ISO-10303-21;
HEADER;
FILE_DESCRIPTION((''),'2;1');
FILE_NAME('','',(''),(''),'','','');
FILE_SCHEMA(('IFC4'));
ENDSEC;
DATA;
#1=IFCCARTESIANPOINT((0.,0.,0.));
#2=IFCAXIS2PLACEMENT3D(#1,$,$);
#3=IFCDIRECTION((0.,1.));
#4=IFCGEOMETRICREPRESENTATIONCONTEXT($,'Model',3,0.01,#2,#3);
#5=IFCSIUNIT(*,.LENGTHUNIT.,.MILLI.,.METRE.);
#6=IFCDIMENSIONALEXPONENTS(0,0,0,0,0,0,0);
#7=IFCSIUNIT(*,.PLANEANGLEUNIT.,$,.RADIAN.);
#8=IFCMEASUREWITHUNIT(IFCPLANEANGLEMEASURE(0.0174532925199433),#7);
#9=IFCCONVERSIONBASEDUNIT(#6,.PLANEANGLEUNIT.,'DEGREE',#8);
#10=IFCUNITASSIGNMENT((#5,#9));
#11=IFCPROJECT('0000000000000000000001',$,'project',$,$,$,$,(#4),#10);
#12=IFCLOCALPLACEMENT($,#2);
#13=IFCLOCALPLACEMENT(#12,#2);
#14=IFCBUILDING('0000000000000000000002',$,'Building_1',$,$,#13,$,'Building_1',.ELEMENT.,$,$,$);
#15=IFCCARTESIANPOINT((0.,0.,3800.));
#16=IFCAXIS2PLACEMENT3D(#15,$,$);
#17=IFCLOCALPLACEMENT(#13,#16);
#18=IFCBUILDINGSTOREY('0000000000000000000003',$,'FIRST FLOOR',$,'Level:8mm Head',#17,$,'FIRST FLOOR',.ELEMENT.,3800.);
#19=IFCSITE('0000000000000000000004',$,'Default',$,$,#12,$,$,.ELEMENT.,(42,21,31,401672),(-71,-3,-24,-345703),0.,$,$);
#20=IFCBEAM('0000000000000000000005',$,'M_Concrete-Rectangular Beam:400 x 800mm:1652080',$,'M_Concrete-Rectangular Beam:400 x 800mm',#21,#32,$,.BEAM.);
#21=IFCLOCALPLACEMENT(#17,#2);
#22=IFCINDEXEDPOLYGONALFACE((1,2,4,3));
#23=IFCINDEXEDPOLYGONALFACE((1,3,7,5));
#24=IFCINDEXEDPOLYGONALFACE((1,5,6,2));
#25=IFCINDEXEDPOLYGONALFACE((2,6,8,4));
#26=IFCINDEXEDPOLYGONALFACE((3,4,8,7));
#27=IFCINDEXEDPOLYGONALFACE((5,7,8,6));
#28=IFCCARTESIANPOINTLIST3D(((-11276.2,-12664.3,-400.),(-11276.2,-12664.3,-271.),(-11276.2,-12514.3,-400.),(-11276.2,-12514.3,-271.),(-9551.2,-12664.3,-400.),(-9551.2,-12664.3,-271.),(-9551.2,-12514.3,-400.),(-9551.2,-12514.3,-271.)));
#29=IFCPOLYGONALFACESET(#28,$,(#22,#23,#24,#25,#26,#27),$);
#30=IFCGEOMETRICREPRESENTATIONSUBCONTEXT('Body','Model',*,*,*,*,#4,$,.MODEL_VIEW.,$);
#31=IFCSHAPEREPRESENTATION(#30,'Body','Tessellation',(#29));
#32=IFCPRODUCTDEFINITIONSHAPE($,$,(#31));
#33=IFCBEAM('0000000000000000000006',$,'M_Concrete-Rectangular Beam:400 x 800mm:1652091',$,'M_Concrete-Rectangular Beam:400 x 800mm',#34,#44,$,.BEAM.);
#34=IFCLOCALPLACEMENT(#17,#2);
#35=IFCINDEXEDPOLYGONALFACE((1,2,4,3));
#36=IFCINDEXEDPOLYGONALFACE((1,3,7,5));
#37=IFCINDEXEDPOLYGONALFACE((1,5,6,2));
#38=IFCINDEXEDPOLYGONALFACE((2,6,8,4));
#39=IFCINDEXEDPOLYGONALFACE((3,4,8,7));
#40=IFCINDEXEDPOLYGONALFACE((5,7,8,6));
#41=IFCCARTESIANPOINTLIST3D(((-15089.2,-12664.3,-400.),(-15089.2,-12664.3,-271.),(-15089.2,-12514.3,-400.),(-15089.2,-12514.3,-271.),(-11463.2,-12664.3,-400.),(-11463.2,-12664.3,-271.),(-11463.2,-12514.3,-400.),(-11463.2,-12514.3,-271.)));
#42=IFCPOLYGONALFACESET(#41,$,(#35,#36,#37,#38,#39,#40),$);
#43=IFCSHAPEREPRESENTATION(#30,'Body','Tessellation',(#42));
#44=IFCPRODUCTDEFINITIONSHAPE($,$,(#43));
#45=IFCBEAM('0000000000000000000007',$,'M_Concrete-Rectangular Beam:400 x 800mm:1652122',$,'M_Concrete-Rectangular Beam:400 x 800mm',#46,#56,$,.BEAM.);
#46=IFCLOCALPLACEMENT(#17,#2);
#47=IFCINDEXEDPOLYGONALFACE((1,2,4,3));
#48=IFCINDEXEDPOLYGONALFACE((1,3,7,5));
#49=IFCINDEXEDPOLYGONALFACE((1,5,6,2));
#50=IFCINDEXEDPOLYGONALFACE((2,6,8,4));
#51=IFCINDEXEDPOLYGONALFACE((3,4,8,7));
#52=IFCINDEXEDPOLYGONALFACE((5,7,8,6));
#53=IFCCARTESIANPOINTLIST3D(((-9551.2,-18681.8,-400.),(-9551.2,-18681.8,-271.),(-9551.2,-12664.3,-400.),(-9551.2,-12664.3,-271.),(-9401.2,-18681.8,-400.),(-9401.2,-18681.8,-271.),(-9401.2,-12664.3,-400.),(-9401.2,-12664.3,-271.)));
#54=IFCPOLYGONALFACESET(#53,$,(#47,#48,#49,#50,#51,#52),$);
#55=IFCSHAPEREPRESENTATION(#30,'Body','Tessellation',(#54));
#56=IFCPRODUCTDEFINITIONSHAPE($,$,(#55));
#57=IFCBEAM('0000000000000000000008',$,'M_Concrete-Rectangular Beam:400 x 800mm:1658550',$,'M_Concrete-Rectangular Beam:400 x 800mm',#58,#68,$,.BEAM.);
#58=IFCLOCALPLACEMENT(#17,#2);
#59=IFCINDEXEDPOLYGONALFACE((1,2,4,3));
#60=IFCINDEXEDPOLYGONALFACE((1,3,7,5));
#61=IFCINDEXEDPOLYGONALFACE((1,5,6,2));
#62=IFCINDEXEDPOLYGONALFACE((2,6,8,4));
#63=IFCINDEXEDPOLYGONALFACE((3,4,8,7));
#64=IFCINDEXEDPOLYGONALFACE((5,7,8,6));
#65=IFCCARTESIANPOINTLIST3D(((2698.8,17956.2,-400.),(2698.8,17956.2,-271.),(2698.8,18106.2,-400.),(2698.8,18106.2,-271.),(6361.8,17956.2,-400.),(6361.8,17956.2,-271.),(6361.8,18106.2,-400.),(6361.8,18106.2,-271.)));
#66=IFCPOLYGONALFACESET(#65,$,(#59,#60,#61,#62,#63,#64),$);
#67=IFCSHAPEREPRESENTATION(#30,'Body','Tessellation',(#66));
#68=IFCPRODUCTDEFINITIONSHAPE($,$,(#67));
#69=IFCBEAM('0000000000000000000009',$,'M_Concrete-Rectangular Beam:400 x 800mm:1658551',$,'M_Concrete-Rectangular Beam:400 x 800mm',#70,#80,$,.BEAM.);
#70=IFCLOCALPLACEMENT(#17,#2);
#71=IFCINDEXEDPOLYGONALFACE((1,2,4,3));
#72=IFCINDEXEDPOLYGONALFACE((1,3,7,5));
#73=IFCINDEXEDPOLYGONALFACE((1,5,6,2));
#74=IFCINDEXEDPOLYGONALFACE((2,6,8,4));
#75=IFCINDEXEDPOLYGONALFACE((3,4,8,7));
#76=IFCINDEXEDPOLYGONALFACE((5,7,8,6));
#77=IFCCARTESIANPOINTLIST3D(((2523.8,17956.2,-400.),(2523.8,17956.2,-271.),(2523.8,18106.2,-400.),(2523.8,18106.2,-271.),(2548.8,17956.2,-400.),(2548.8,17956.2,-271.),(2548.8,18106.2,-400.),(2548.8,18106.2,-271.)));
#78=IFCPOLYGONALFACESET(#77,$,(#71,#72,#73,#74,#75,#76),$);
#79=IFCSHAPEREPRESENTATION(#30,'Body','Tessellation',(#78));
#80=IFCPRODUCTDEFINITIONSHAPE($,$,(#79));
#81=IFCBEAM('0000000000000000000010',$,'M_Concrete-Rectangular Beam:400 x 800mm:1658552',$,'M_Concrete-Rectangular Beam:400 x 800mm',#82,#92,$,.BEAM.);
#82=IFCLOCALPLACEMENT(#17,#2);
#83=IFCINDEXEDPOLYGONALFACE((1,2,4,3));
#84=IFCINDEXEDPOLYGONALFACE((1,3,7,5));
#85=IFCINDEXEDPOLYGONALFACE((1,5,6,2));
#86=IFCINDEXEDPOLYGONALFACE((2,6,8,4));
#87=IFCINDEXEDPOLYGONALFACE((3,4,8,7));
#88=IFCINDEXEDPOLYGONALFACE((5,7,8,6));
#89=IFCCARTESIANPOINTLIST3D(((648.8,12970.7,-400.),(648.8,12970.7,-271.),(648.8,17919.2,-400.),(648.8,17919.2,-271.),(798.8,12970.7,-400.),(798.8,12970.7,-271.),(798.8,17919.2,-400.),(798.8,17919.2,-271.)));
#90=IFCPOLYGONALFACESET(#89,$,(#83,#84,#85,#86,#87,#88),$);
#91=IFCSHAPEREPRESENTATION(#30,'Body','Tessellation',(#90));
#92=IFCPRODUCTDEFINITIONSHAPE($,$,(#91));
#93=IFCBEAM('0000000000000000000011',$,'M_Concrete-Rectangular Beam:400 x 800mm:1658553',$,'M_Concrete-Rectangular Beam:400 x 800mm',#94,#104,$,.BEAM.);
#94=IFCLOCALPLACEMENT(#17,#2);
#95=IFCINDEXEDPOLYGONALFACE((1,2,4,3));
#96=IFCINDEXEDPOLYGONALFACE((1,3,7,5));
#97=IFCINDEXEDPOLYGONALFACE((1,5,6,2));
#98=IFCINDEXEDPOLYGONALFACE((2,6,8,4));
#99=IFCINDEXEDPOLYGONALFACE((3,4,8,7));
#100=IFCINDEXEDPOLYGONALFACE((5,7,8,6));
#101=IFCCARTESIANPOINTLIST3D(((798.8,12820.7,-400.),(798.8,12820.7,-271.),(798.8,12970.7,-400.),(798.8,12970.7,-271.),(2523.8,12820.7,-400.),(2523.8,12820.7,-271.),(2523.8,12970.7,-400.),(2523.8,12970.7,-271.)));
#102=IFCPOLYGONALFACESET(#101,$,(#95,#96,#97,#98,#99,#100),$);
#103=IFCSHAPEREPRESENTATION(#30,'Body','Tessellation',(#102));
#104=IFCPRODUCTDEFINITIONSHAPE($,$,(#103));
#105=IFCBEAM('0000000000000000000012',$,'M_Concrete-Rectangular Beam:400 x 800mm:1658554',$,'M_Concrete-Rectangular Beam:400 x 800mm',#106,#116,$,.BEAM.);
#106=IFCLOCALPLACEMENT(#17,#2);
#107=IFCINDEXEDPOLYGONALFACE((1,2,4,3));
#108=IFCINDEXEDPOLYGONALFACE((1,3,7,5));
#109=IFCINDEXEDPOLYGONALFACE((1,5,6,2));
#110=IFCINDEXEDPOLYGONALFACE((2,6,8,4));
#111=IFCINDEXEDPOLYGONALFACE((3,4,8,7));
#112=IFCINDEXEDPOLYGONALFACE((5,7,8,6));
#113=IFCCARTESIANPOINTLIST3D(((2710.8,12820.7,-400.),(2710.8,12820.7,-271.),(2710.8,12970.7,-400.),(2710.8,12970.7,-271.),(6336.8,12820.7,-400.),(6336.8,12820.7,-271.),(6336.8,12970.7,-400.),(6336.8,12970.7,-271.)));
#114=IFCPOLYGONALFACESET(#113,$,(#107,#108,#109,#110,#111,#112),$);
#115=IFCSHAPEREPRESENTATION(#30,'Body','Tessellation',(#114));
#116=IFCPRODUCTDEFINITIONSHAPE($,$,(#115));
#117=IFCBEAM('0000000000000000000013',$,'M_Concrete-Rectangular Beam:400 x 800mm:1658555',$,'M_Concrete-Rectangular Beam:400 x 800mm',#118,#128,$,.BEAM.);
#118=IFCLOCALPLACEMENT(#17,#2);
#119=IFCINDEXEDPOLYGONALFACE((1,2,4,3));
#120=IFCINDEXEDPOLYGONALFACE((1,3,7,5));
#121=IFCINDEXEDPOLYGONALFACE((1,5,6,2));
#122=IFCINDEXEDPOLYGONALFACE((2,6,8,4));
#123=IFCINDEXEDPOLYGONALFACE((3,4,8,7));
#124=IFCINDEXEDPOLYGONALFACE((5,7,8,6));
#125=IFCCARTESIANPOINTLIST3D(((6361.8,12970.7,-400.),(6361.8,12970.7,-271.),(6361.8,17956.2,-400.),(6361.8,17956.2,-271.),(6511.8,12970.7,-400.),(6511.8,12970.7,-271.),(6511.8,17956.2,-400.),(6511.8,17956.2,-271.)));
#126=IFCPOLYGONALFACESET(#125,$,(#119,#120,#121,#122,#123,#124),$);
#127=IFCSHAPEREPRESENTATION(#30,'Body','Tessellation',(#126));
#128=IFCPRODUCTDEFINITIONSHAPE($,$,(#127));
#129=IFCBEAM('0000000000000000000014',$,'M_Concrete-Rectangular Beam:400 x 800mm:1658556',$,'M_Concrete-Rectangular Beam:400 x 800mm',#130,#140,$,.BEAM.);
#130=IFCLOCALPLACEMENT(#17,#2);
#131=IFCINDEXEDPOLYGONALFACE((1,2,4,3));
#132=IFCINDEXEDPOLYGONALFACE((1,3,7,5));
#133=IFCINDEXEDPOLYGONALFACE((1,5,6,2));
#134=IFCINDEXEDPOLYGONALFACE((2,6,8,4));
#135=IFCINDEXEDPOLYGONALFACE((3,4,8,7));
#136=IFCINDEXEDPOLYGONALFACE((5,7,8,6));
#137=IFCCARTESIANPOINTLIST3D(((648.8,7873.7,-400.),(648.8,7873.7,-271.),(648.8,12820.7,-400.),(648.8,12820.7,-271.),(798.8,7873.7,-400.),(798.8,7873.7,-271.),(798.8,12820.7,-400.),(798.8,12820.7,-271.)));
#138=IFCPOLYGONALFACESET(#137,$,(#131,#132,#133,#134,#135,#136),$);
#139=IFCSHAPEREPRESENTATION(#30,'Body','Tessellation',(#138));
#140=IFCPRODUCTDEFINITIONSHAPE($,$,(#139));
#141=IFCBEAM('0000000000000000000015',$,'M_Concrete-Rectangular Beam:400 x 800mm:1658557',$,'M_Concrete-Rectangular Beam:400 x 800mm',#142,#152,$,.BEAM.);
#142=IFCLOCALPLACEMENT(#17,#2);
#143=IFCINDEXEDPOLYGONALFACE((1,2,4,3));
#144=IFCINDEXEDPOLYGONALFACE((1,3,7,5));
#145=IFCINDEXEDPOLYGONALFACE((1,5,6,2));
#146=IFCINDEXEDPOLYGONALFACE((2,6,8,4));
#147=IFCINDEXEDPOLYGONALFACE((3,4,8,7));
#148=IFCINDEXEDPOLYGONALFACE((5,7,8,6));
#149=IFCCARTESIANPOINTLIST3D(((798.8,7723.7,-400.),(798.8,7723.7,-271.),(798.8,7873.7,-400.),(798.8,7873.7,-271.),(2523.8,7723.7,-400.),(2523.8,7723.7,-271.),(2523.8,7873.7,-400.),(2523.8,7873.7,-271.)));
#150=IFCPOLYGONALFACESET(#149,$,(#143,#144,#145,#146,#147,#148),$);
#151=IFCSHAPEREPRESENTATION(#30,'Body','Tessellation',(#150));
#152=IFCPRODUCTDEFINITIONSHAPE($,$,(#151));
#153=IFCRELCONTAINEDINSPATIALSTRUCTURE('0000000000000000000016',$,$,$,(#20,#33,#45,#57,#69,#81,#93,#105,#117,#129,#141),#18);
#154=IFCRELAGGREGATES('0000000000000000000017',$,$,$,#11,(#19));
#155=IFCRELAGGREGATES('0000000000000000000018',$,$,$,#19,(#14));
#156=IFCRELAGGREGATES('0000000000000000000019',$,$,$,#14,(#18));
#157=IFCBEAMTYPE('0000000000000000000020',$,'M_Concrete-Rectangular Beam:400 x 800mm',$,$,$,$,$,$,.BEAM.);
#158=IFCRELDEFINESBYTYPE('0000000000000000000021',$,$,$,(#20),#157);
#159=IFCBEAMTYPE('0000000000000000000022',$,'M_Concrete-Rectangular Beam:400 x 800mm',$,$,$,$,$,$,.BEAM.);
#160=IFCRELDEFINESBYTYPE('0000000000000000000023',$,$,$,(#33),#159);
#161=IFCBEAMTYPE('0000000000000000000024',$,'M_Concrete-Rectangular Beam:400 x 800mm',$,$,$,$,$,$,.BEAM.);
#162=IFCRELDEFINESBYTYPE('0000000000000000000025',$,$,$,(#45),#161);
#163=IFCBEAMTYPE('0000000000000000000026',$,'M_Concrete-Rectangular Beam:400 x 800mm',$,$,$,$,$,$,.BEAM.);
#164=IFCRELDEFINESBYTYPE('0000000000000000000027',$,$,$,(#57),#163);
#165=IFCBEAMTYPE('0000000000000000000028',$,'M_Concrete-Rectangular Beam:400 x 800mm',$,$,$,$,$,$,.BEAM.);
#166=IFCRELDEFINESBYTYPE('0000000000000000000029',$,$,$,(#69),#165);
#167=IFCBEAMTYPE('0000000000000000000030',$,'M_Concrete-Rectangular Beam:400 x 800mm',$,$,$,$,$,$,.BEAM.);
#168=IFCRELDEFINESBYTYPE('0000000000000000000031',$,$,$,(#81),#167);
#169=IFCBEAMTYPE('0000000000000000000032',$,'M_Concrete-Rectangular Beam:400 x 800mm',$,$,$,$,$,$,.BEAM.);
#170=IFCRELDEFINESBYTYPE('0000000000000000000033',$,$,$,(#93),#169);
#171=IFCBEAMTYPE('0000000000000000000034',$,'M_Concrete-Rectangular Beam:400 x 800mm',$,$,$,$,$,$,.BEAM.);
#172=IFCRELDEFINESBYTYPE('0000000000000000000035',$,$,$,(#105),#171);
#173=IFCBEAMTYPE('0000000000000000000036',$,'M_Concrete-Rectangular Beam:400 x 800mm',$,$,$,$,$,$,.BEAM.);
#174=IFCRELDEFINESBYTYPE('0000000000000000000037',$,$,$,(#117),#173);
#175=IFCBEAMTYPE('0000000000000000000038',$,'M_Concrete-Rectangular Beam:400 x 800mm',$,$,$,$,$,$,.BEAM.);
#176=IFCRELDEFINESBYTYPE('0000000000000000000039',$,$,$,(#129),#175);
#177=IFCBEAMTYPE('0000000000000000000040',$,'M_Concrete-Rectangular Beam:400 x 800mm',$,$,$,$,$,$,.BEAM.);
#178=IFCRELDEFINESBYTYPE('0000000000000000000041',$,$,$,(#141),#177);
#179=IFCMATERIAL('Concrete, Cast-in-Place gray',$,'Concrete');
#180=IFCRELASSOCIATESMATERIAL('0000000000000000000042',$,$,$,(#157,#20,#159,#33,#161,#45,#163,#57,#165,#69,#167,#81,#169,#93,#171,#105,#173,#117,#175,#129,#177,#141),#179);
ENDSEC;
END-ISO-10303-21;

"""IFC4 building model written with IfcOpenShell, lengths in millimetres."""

from ifc_helpers import new_model, entity, si_unit, converted_unit, direction, frame, origin, place, context, subcontext, project, spatial, indexed_curve, outline, extrude, source, transform, mapped, material, type_object, type_shapes, element, save


model = new_model("IFC4")

# Units and contexts
model_context = context("Model", 3, precision=0.01, world=origin(), true_north=direction((0.0, 1.0)))
body_context = subcontext(model_context, "Body", "Model", "MODEL_VIEW")
ifc_project = project(units=[si_unit("LENGTHUNIT", "METRE", prefix="MILLI"), converted_unit("PLANEANGLEUNIT", "DEGREE", entity("IfcPlaneAngleMeasure", 0.0174532925199433), si_unit("PLANEANGLEUNIT", "RADIAN"), dimensions=[0, 0, 0, 0, 0, 0, 0])], contexts=[model_context])

# Site, building, storey
site_placement = place(None, origin())
site = spatial("IfcSite", under=ifc_project, at=site_placement, Name="Default", CompositionType="ELEMENT", RefLatitude=(42, 21, 31, 401672), RefLongitude=(-71, -3, -24, -345703), RefElevation=0.0)
building_placement = place(site_placement, origin())
building = spatial("IfcBuilding", under=site, at=building_placement, Name="Building_1", LongName="Building_1", CompositionType="ELEMENT")
storey_placement = place(building_placement, frame((0.0, 0.0, 3800.0)))
storey = spatial("IfcBuildingStorey", under=building, at=storey_placement, Name="FIRST FLOOR", ObjectType="Level:8mm Head", LongName="FIRST FLOOR", CompositionType="ELEMENT", Elevation=3800.0)

# Beams
ifc_material = material(Name="Concrete, Cast-in-Place gray", Category="Concrete")
beam_type_1 = type_object("IfcBeamType", Name="M_Concrete-Rectangular Beam:400 x 800mm", PredefinedType="BEAM", material=ifc_material)
shared_shape_1 = source(origin(), body_context, "Body", "SweptSolid", [
    extrude(outline(indexed_curve([(-64.5, -75.0), (64.5, -75.0), (64.5, 75.0), (-64.5, 75.0), (-64.5, -75.0)], self_intersect=False)), frame((-9551.2, -12589.3, 3464.5), z_axis=(-1.0, 0.0, 0.0), x_axis=(0.0, 0.0, -1.0)), (0.0, 0.0, 1.0), 1725.0),
])
type_shapes(beam_type_1, [shared_shape_1])
beam_1_placement = place(storey_placement, frame((0.0, 0.0, -3800.0)))
element("IfcBeam", 1, at=beam_1_placement, inside=storey, type_object=beam_type_1, material=ifc_material, Name="M_Concrete-Rectangular Beam:400 x 800mm:1652080", ObjectType="M_Concrete-Rectangular Beam:400 x 800mm", PredefinedType="BEAM", context=body_context, shape_type="MappedRepresentation", body=[
    mapped(shared_shape_1, transform((0.0, 0.0, 0.0), scale=1.0)),
])
beam_type_2 = type_object("IfcBeamType", Name="M_Concrete-Rectangular Beam:400 x 800mm", PredefinedType="BEAM", material=ifc_material)
shared_shape_2 = source(origin(), body_context, "Body", "SweptSolid", [
    extrude(outline(indexed_curve([(-64.5, -75.0), (64.5, -75.0), (64.5, 75.0), (-64.5, 75.0), (-64.5, -75.0)], self_intersect=False)), frame((-11463.2, -12589.3, 3464.5), z_axis=(-1.0, 0.0, 0.0), x_axis=(0.0, 0.0, -1.0)), (0.0, 0.0, 1.0), 3626.0),
])
type_shapes(beam_type_2, [shared_shape_2])
beam_2_placement = place(storey_placement, frame((0.0, 0.0, -3800.0)))
element("IfcBeam", 2, at=beam_2_placement, inside=storey, type_object=beam_type_2, material=ifc_material, Name="M_Concrete-Rectangular Beam:400 x 800mm:1652091", ObjectType="M_Concrete-Rectangular Beam:400 x 800mm", PredefinedType="BEAM", context=body_context, shape_type="MappedRepresentation", body=[
    mapped(shared_shape_2, transform((0.0, 0.0, 0.0), scale=1.0)),
])
beam_type_3 = type_object("IfcBeamType", Name="M_Concrete-Rectangular Beam:400 x 800mm", PredefinedType="BEAM", material=ifc_material)
shared_shape_3 = source(origin(), body_context, "Body", "SweptSolid", [
    extrude(outline(indexed_curve([(-75.0, -64.5), (75.0, -64.5), (75.0, 64.5), (-75.0, 64.5), (-75.0, -64.5)], self_intersect=False)), frame((-9476.2, -12664.3, 3464.5), z_axis=(0.0, -1.0, 0.0), x_axis=(-1.0, 0.0, 0.0)), (0.0, 0.0, 1.0), 6017.5),
])
type_shapes(beam_type_3, [shared_shape_3])
beam_3_placement = place(storey_placement, frame((0.0, 0.0, -3800.0)))
element("IfcBeam", 3, at=beam_3_placement, inside=storey, type_object=beam_type_3, material=ifc_material, Name="M_Concrete-Rectangular Beam:400 x 800mm:1652122", ObjectType="M_Concrete-Rectangular Beam:400 x 800mm", PredefinedType="BEAM", context=body_context, shape_type="MappedRepresentation", body=[
    mapped(shared_shape_3, transform((0.0, 0.0, 0.0), scale=1.0)),
])
beam_type_4 = type_object("IfcBeamType", Name="M_Concrete-Rectangular Beam:400 x 800mm", PredefinedType="BEAM", material=ifc_material)
shared_shape_4 = source(origin(), body_context, "Body", "SweptSolid", [
    extrude(outline(indexed_curve([(-64.5, -75.0), (64.5, -75.0), (64.5, 75.0), (-64.5, 75.0), (-64.5, -75.0)], self_intersect=False)), frame((6361.8, 18031.2, 3464.5), z_axis=(-1.0, 0.0, 0.0), x_axis=(0.0, 0.0, -1.0)), (0.0, 0.0, 1.0), 3663.0),
])
type_shapes(beam_type_4, [shared_shape_4])
beam_4_placement = place(storey_placement, frame((0.0, 0.0, -3800.0)))
element("IfcBeam", 4, at=beam_4_placement, inside=storey, type_object=beam_type_4, material=ifc_material, Name="M_Concrete-Rectangular Beam:400 x 800mm:1658550", ObjectType="M_Concrete-Rectangular Beam:400 x 800mm", PredefinedType="BEAM", context=body_context, shape_type="MappedRepresentation", body=[
    mapped(shared_shape_4, transform((0.0, 0.0, 0.0), scale=1.0)),
])
beam_type_5 = type_object("IfcBeamType", Name="M_Concrete-Rectangular Beam:400 x 800mm", PredefinedType="BEAM", material=ifc_material)
shared_shape_5 = source(origin(), body_context, "Body", "SweptSolid", [
    extrude(outline(indexed_curve([(-64.5, -75.0), (64.5, -75.0), (64.5, 75.0), (-64.5, 75.0), (-64.5, -75.0)], self_intersect=False)), frame((2548.8, 18031.2, 3464.5), z_axis=(-1.0, 0.0, 0.0), x_axis=(0.0, 0.0, -1.0)), (0.0, 0.0, 1.0), 25.0),
])
type_shapes(beam_type_5, [shared_shape_5])
beam_5_placement = place(storey_placement, frame((0.0, 0.0, -3800.0)))
element("IfcBeam", 5, at=beam_5_placement, inside=storey, type_object=beam_type_5, material=ifc_material, Name="M_Concrete-Rectangular Beam:400 x 800mm:1658551", ObjectType="M_Concrete-Rectangular Beam:400 x 800mm", PredefinedType="BEAM", context=body_context, shape_type="MappedRepresentation", body=[
    mapped(shared_shape_5, transform((0.0, 0.0, 0.0), scale=1.0)),
])
beam_type_6 = type_object("IfcBeamType", Name="M_Concrete-Rectangular Beam:400 x 800mm", PredefinedType="BEAM", material=ifc_material)
shared_shape_6 = source(origin(), body_context, "Body", "SweptSolid", [
    extrude(outline(indexed_curve([(-75.0, -64.5), (75.0, -64.5), (75.0, 64.5), (-75.0, 64.5), (-75.0, -64.5)], self_intersect=False)), frame((723.8, 17919.2, 3464.5), z_axis=(0.0, -1.0, 0.0), x_axis=(-1.0, 0.0, 0.0)), (0.0, 0.0, 1.0), 4948.5),
])
type_shapes(beam_type_6, [shared_shape_6])
beam_6_placement = place(storey_placement, frame((0.0, 0.0, -3800.0)))
element("IfcBeam", 6, at=beam_6_placement, inside=storey, type_object=beam_type_6, material=ifc_material, Name="M_Concrete-Rectangular Beam:400 x 800mm:1658552", ObjectType="M_Concrete-Rectangular Beam:400 x 800mm", PredefinedType="BEAM", context=body_context, shape_type="MappedRepresentation", body=[
    mapped(shared_shape_6, transform((0.0, 0.0, 0.0), scale=1.0)),
])
beam_type_7 = type_object("IfcBeamType", Name="M_Concrete-Rectangular Beam:400 x 800mm", PredefinedType="BEAM", material=ifc_material)
shared_shape_7 = source(origin(), body_context, "Body", "SweptSolid", [
    extrude(outline(indexed_curve([(-64.5, -75.0), (64.5, -75.0), (64.5, 75.0), (-64.5, 75.0), (-64.5, -75.0)], self_intersect=False)), frame((798.8, 12895.7, 3464.5), z_axis=(1.0, 0.0, 0.0), x_axis=(0.0, 0.0, -1.0)), (0.0, 0.0, 1.0), 1725.0),
])
type_shapes(beam_type_7, [shared_shape_7])
beam_7_placement = place(storey_placement, frame((0.0, 0.0, -3800.0)))
element("IfcBeam", 7, at=beam_7_placement, inside=storey, type_object=beam_type_7, material=ifc_material, Name="M_Concrete-Rectangular Beam:400 x 800mm:1658553", ObjectType="M_Concrete-Rectangular Beam:400 x 800mm", PredefinedType="BEAM", context=body_context, shape_type="MappedRepresentation", body=[
    mapped(shared_shape_7, transform((0.0, 0.0, 0.0), scale=1.0)),
])
beam_type_8 = type_object("IfcBeamType", Name="M_Concrete-Rectangular Beam:400 x 800mm", PredefinedType="BEAM", material=ifc_material)
shared_shape_8 = source(origin(), body_context, "Body", "SweptSolid", [
    extrude(outline(indexed_curve([(-64.5, -75.0), (64.5, -75.0), (64.5, 75.0), (-64.5, 75.0), (-64.5, -75.0)], self_intersect=False)), frame((2710.8, 12895.7, 3464.5), z_axis=(1.0, 0.0, 0.0), x_axis=(0.0, 0.0, -1.0)), (0.0, 0.0, 1.0), 3626.0),
])
type_shapes(beam_type_8, [shared_shape_8])
beam_8_placement = place(storey_placement, frame((0.0, 0.0, -3800.0)))
element("IfcBeam", 8, at=beam_8_placement, inside=storey, type_object=beam_type_8, material=ifc_material, Name="M_Concrete-Rectangular Beam:400 x 800mm:1658554", ObjectType="M_Concrete-Rectangular Beam:400 x 800mm", PredefinedType="BEAM", context=body_context, shape_type="MappedRepresentation", body=[
    mapped(shared_shape_8, transform((0.0, 0.0, 0.0), scale=1.0)),
])
beam_type_9 = type_object("IfcBeamType", Name="M_Concrete-Rectangular Beam:400 x 800mm", PredefinedType="BEAM", material=ifc_material)
shared_shape_9 = source(origin(), body_context, "Body", "SweptSolid", [
    extrude(outline(indexed_curve([(-75.0, -64.5), (75.0, -64.5), (75.0, 64.5), (-75.0, 64.5), (-75.0, -64.5)], self_intersect=False)), frame((6436.8, 12970.7, 3464.5), z_axis=(0.0, 1.0, 0.0), x_axis=(-1.0, 0.0, 0.0)), (0.0, 0.0, 1.0), 4985.5),
])
type_shapes(beam_type_9, [shared_shape_9])
beam_9_placement = place(storey_placement, frame((0.0, 0.0, -3800.0)))
element("IfcBeam", 9, at=beam_9_placement, inside=storey, type_object=beam_type_9, material=ifc_material, Name="M_Concrete-Rectangular Beam:400 x 800mm:1658555", ObjectType="M_Concrete-Rectangular Beam:400 x 800mm", PredefinedType="BEAM", context=body_context, shape_type="MappedRepresentation", body=[
    mapped(shared_shape_9, transform((0.0, 0.0, 0.0), scale=1.0)),
])
beam_type_10 = type_object("IfcBeamType", Name="M_Concrete-Rectangular Beam:400 x 800mm", PredefinedType="BEAM", material=ifc_material)
shared_shape_10 = source(origin(), body_context, "Body", "SweptSolid", [
    extrude(outline(indexed_curve([(-75.0, -64.5), (75.0, -64.5), (75.0, 64.5), (-75.0, 64.5), (-75.0, -64.5)], self_intersect=False)), frame((723.8, 12820.7, 3464.5), z_axis=(0.0, -1.0, 0.0), x_axis=(-1.0, 0.0, 0.0)), (0.0, 0.0, 1.0), 4947.0),
])
type_shapes(beam_type_10, [shared_shape_10])
beam_10_placement = place(storey_placement, frame((0.0, 0.0, -3800.0)))
element("IfcBeam", 10, at=beam_10_placement, inside=storey, type_object=beam_type_10, material=ifc_material, Name="M_Concrete-Rectangular Beam:400 x 800mm:1658556", ObjectType="M_Concrete-Rectangular Beam:400 x 800mm", PredefinedType="BEAM", context=body_context, shape_type="MappedRepresentation", body=[
    mapped(shared_shape_10, transform((0.0, 0.0, 0.0), scale=1.0)),
])
beam_type_11 = type_object("IfcBeamType", Name="M_Concrete-Rectangular Beam:400 x 800mm", PredefinedType="BEAM", material=ifc_material)
shared_shape_11 = source(origin(), body_context, "Body", "SweptSolid", [
    extrude(outline(indexed_curve([(-64.5, -75.0), (64.5, -75.0), (64.5, 75.0), (-64.5, 75.0), (-64.5, -75.0)], self_intersect=False)), frame((798.8, 7798.7, 3464.5), z_axis=(1.0, 0.0, 0.0), x_axis=(0.0, 0.0, -1.0)), (0.0, 0.0, 1.0), 1725.0),
])
type_shapes(beam_type_11, [shared_shape_11])
beam_11_placement = place(storey_placement, frame((0.0, 0.0, -3800.0)))
element("IfcBeam", 11, at=beam_11_placement, inside=storey, type_object=beam_type_11, material=ifc_material, Name="M_Concrete-Rectangular Beam:400 x 800mm:1658557", ObjectType="M_Concrete-Rectangular Beam:400 x 800mm", PredefinedType="BEAM", context=body_context, shape_type="MappedRepresentation", body=[
    mapped(shared_shape_11, transform((0.0, 0.0, 0.0), scale=1.0)),
])

save(model, "model.ifc")
